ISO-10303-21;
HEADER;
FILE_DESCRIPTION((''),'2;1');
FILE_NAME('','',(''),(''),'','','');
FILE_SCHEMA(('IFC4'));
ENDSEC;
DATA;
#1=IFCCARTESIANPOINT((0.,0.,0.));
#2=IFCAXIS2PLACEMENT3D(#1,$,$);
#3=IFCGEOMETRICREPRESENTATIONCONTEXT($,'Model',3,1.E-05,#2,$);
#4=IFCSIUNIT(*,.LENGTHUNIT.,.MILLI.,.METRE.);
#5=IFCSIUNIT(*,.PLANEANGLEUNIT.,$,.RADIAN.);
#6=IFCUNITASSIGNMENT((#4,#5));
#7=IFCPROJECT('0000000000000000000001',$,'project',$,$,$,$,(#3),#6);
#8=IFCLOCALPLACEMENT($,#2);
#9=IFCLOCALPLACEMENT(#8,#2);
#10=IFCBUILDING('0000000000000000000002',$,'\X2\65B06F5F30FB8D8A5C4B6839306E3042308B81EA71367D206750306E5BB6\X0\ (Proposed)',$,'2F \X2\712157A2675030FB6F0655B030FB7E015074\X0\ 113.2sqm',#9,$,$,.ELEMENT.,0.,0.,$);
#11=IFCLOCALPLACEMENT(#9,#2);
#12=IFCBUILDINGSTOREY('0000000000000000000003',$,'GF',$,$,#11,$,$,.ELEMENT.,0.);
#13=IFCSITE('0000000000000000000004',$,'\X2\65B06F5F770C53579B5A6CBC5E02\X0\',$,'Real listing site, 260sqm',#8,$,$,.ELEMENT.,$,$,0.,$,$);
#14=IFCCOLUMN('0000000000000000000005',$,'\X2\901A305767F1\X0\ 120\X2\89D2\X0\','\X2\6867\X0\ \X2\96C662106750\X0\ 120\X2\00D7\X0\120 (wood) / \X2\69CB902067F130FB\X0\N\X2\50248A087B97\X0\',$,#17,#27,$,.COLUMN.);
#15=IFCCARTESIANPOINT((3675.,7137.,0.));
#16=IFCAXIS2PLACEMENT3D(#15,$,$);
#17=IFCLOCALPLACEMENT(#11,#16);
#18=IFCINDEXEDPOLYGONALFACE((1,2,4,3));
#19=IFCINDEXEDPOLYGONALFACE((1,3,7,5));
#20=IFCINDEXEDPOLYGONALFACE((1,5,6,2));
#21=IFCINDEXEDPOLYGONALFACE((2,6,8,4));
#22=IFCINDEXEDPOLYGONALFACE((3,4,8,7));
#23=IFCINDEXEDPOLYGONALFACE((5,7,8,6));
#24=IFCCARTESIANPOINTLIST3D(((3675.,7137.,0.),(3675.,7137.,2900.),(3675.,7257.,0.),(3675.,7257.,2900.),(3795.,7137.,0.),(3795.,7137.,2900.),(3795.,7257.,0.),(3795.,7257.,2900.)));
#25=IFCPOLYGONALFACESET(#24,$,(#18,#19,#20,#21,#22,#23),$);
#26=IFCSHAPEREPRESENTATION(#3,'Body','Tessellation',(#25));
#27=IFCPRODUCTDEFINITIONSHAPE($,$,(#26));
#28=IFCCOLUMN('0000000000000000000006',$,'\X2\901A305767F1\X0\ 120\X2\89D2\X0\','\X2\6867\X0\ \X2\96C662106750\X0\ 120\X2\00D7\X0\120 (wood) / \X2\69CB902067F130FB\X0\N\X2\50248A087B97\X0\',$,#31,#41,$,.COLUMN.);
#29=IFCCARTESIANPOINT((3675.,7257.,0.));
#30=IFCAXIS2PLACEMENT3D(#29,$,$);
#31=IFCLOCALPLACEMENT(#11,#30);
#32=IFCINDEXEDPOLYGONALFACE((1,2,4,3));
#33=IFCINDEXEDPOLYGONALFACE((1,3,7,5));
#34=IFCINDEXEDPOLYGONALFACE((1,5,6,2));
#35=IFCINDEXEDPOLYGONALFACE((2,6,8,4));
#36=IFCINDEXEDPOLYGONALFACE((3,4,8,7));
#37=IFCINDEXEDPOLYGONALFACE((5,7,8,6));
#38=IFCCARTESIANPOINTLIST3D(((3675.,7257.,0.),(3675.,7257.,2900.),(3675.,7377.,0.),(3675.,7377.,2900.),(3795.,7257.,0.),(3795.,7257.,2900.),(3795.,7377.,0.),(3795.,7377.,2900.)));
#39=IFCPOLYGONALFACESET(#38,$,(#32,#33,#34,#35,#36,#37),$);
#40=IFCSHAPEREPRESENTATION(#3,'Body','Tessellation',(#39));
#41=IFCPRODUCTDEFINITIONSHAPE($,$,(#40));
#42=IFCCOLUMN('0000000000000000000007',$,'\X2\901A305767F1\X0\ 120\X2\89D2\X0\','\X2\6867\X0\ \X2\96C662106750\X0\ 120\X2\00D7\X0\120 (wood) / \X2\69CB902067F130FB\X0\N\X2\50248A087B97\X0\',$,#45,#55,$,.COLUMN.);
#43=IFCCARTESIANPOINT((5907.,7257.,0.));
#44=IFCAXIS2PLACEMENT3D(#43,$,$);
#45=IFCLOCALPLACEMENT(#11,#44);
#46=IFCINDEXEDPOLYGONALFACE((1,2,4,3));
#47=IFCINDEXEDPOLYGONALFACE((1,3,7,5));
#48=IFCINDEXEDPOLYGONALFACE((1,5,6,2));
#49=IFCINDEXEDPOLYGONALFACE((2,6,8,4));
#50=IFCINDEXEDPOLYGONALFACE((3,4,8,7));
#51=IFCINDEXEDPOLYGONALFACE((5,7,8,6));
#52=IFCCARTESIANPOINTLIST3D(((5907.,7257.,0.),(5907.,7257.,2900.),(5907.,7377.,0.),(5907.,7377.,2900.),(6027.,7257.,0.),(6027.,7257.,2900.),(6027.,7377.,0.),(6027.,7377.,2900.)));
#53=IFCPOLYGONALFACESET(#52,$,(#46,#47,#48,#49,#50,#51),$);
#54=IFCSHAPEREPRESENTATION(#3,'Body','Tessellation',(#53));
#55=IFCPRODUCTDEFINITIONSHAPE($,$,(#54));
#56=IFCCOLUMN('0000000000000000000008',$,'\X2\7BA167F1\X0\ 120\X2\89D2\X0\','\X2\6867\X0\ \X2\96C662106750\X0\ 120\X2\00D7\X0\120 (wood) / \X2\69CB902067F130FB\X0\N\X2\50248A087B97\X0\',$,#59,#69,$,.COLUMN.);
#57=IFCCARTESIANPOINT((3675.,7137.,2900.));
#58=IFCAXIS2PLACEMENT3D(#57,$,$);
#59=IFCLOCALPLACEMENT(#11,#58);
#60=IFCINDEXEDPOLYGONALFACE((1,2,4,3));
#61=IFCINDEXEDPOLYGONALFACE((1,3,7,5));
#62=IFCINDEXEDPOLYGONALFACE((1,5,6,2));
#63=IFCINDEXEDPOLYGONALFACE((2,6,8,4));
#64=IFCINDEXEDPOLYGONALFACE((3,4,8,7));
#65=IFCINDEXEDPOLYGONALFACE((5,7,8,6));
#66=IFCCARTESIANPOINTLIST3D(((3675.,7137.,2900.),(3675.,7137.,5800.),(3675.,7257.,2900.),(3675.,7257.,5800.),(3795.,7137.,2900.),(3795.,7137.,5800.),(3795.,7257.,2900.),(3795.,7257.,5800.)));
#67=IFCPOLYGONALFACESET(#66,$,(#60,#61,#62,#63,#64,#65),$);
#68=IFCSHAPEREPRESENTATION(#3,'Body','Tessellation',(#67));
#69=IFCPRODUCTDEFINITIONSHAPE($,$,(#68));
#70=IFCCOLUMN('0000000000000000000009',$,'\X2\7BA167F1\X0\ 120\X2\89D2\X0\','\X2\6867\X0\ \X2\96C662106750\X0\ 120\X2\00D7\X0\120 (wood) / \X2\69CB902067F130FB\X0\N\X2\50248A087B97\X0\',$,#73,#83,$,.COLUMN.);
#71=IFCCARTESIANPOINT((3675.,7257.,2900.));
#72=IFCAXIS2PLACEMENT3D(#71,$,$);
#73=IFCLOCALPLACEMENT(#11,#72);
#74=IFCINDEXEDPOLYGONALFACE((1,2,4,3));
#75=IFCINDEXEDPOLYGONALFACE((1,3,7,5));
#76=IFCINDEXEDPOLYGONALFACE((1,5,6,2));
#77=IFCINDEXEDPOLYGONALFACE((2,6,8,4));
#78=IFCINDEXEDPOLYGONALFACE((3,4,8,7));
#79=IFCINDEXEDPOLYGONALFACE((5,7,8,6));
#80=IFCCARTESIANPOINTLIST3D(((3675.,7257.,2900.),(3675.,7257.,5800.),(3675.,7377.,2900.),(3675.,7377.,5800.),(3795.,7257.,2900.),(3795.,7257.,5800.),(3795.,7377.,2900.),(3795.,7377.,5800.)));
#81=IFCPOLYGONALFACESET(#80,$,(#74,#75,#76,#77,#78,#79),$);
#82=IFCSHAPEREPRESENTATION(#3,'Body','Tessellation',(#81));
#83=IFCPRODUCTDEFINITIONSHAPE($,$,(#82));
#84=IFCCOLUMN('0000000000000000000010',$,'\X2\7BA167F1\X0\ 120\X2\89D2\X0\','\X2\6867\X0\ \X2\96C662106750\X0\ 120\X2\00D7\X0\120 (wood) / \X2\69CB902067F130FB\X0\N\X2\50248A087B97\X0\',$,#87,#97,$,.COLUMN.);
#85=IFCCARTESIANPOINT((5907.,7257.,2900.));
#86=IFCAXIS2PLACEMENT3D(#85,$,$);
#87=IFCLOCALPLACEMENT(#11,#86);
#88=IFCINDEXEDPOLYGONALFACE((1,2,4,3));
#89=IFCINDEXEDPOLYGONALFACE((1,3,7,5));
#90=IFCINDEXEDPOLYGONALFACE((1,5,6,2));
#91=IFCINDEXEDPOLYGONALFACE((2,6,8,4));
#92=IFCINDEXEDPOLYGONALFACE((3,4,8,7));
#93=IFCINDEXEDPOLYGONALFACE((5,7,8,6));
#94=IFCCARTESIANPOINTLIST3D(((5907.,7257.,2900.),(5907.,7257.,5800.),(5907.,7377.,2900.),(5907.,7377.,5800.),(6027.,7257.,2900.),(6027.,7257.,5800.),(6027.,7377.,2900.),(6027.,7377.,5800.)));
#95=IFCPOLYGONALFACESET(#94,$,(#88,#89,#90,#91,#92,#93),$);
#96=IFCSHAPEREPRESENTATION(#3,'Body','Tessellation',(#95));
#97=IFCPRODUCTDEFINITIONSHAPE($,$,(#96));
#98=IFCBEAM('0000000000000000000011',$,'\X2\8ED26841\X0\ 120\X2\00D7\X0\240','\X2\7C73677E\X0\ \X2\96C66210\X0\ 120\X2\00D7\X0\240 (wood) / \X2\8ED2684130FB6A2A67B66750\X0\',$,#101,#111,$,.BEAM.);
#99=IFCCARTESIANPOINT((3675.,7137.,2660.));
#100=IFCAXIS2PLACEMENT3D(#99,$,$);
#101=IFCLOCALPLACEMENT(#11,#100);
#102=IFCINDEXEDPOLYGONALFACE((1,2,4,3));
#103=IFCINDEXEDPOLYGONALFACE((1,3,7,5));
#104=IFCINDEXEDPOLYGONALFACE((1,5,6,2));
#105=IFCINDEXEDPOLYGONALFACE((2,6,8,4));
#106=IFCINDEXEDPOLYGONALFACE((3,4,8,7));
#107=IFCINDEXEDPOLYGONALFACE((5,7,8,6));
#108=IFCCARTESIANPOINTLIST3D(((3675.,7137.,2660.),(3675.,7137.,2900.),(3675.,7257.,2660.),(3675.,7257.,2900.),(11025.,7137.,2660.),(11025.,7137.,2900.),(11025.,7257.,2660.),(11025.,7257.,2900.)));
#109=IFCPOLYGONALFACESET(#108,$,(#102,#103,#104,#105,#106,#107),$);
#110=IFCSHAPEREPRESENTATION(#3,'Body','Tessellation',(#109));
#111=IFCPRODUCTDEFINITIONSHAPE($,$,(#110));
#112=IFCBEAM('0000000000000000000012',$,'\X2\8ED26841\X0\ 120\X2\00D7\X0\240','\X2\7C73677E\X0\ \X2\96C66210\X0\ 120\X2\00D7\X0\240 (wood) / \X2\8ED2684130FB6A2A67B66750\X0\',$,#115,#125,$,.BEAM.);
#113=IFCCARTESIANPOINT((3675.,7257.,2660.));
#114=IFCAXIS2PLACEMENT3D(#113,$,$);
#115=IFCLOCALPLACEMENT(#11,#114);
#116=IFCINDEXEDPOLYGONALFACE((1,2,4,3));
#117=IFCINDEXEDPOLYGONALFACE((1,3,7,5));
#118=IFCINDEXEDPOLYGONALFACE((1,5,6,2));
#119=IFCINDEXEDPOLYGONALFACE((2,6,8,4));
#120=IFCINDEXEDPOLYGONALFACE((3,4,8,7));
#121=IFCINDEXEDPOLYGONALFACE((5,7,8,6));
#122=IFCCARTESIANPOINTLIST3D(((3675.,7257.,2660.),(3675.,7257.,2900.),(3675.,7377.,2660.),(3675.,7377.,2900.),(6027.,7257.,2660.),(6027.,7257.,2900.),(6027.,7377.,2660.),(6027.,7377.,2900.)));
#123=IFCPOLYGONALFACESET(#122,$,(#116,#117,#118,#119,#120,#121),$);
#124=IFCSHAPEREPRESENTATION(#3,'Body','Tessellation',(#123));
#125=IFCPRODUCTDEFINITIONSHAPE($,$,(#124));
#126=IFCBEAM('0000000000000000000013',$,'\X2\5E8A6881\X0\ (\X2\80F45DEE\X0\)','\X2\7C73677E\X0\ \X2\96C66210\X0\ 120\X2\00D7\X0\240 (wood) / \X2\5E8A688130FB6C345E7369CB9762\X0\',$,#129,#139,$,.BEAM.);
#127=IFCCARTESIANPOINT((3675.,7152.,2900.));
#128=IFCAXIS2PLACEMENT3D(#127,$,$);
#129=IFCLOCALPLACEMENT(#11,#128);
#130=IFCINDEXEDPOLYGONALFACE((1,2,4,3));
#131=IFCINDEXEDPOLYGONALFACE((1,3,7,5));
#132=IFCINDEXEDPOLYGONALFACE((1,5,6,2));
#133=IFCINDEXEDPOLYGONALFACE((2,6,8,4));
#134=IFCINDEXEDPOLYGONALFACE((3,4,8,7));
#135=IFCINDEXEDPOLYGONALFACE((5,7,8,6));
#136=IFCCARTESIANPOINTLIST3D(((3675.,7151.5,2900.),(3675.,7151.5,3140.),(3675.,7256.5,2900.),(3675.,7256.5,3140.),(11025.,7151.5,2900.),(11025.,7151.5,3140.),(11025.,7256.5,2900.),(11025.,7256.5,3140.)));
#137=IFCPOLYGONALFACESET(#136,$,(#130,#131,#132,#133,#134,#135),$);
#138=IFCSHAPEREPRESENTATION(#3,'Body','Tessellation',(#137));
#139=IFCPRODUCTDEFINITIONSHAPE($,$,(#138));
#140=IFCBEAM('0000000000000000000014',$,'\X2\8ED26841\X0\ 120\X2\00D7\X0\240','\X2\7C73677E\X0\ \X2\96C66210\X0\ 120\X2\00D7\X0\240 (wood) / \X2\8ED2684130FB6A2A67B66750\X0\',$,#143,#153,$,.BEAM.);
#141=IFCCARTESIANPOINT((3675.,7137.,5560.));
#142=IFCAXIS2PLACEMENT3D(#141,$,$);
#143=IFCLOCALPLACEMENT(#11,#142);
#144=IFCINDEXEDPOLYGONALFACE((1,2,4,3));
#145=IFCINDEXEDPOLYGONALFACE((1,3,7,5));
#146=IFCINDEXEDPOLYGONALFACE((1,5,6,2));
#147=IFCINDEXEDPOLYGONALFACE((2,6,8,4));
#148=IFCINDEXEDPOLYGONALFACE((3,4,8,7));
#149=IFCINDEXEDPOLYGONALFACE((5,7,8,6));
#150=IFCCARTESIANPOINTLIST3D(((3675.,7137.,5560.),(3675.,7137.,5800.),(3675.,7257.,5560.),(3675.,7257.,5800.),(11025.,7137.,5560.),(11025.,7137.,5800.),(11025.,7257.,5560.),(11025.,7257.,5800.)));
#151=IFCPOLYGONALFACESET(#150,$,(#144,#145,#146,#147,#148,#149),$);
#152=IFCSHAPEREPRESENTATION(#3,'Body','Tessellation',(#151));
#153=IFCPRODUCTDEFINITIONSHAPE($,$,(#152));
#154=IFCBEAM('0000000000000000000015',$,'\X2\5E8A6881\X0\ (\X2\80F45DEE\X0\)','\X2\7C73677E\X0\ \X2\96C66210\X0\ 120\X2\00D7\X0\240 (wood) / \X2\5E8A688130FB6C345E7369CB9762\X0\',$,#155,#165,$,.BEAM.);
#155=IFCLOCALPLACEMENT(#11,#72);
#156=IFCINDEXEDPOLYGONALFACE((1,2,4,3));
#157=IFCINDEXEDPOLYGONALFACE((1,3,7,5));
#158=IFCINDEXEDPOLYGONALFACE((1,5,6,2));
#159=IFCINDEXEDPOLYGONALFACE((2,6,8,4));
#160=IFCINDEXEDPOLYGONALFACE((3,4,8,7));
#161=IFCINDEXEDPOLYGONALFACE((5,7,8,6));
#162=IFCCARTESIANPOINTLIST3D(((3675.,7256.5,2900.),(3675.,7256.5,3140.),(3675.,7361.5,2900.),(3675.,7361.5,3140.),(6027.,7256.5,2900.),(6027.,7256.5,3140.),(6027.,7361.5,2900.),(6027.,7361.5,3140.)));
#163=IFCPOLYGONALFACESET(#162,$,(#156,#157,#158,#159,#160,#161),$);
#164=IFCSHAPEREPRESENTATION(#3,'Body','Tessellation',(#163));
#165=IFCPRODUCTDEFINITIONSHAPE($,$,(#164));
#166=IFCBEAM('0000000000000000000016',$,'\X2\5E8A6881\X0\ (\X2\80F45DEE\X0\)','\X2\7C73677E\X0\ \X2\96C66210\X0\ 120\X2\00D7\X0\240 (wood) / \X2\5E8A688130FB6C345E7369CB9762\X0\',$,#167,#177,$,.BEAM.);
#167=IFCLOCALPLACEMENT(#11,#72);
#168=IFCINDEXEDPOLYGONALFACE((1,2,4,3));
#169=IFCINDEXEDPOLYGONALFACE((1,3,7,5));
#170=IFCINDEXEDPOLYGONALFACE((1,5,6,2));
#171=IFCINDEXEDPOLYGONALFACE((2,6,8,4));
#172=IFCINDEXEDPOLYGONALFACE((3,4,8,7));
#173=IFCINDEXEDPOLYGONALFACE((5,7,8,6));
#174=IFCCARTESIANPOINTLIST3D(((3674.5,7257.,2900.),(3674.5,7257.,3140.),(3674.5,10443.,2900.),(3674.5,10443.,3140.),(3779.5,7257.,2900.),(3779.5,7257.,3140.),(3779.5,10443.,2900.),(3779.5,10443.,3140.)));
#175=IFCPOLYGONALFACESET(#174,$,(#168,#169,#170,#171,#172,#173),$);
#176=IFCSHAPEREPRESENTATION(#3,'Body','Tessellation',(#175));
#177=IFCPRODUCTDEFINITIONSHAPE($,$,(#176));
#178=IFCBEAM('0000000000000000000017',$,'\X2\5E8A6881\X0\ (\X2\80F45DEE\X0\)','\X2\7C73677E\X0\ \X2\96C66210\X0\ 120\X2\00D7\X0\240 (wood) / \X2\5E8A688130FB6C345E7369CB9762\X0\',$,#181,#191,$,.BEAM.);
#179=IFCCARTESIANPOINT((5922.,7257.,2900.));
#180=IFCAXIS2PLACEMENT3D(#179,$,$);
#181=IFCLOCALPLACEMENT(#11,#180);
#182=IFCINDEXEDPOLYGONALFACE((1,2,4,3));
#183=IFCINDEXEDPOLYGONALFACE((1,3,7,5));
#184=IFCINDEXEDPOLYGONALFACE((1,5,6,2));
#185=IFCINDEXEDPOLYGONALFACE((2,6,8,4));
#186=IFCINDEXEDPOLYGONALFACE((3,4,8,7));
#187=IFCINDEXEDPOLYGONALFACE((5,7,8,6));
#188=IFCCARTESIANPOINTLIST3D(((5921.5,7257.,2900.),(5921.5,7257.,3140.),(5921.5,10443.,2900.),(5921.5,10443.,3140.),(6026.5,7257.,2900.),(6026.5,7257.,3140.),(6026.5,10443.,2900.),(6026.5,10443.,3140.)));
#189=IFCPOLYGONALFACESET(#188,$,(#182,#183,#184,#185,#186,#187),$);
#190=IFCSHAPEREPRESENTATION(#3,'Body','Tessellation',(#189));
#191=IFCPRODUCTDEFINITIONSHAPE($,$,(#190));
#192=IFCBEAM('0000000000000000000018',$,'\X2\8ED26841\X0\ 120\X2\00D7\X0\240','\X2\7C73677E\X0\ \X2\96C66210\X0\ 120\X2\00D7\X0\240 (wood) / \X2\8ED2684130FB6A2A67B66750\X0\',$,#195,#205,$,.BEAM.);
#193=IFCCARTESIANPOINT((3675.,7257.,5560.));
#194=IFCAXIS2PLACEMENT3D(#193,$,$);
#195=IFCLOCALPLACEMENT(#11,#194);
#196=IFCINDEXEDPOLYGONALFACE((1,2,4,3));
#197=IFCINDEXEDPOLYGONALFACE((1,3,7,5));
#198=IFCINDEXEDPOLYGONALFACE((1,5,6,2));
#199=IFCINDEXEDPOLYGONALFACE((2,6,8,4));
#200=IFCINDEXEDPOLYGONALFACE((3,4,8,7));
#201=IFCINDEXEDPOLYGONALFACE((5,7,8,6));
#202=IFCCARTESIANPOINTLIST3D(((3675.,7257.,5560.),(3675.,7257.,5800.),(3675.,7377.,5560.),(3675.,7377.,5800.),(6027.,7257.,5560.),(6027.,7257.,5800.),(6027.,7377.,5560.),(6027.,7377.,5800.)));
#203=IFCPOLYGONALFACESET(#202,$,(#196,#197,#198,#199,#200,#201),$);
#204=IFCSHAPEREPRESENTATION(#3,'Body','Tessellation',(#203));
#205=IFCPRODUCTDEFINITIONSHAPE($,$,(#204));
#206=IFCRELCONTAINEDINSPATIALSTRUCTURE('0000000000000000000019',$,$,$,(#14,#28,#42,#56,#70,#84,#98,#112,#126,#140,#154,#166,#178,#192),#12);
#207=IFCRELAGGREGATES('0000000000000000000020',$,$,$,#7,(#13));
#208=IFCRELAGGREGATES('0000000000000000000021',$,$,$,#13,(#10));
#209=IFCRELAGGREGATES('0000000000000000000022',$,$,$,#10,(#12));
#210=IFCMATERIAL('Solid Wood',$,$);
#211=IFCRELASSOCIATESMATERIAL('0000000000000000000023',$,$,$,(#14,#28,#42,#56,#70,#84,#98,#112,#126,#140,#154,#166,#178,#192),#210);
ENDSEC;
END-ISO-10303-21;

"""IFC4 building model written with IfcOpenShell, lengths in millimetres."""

from ifc_helpers import new_model, si_unit, frame, frame_2d, origin, place, context, project, spatial, rectangle, extrude, material, element, save


model = new_model("IFC4")

# Units and contexts
model_context = context("Model", 3, precision=1e-05, world=origin())
ifc_project = project(units=[si_unit("LENGTHUNIT", "METRE", prefix="MILLI"), si_unit("PLANEANGLEUNIT", "RADIAN")], contexts=[model_context])

# Site, building, storey
site_placement = place(None, origin())
site = spatial("IfcSite", under=ifc_project, at=site_placement, Name="新潟県南魚沼市", ObjectType="Real listing site, 260sqm", CompositionType="ELEMENT", RefElevation=0.0)
building_placement = place(site_placement, origin())
building = spatial("IfcBuilding", under=site, at=building_placement, Name="新潟・越屋根のある自然素材の家 (Proposed)", ObjectType="2F 無垢材・漆喰・縁側 113.2sqm", CompositionType="ELEMENT", ElevationOfRefHeight=0.0, ElevationOfTerrain=0.0)
storey_placement = place(building_placement, origin())
storey = spatial("IfcBuildingStorey", under=building, at=storey_placement, Name="GF", CompositionType="ELEMENT", Elevation=0.0)

# Columns
ifc_material_1 = material(Name="Solid Wood")
column_1_placement = place(storey_placement, frame((3675.0, 7137.0, 0.0)))
element("IfcColumn", 1, at=column_1_placement, inside=storey, material=ifc_material_1, Name="通し柱 120角", Description="桧 集成材 120×120 (wood) / 構造柱・N値計算", PredefinedType="COLUMN", context=model_context, shape_type="SweptSolid", body=[
    extrude(rectangle(XDim=120.0, YDim=120.0, at=frame_2d((60.0, 60.0))), frame((3675.0, 7137.0, 0.0)), (0.0, 0.0, 1.0), 2900.0),
])
column_2_placement = place(storey_placement, frame((3675.0, 7257.0, 0.0)))
element("IfcColumn", 2, at=column_2_placement, inside=storey, material=ifc_material_1, Name="通し柱 120角", Description="桧 集成材 120×120 (wood) / 構造柱・N値計算", PredefinedType="COLUMN", context=model_context, shape_type="SweptSolid", body=[
    extrude(rectangle(XDim=120.0, YDim=120.0, at=frame_2d((60.0, 60.0))), frame((3675.0, 7257.0, 0.0)), (0.0, 0.0, 1.0), 2900.0),
])
column_3_placement = place(storey_placement, frame((5907.0, 7257.0, 0.0)))
element("IfcColumn", 3, at=column_3_placement, inside=storey, material=ifc_material_1, Name="通し柱 120角", Description="桧 集成材 120×120 (wood) / 構造柱・N値計算", PredefinedType="COLUMN", context=model_context, shape_type="SweptSolid", body=[
    extrude(rectangle(XDim=120.0, YDim=120.0, at=frame_2d((60.0, 60.0))), frame((5907.0, 7257.0, 0.0)), (0.0, 0.0, 1.0), 2900.0),
])
column_4_placement = place(storey_placement, frame((3675.0, 7137.0, 2900.0)))
element("IfcColumn", 4, at=column_4_placement, inside=storey, material=ifc_material_1, Name="管柱 120角", Description="桧 集成材 120×120 (wood) / 構造柱・N値計算", PredefinedType="COLUMN", context=model_context, shape_type="SweptSolid", body=[
    extrude(rectangle(XDim=120.0, YDim=120.0, at=frame_2d((60.0, 60.0))), frame((3675.0, 7137.0, 2900.0)), (0.0, 0.0, 1.0), 2900.0),
])
column_5_placement = place(storey_placement, frame((3675.0, 7257.0, 2900.0)))
element("IfcColumn", 5, at=column_5_placement, inside=storey, material=ifc_material_1, Name="管柱 120角", Description="桧 集成材 120×120 (wood) / 構造柱・N値計算", PredefinedType="COLUMN", context=model_context, shape_type="SweptSolid", body=[
    extrude(rectangle(XDim=120.0, YDim=120.0, at=frame_2d((60.0, 60.0))), frame((3675.0, 7257.0, 2900.0)), (0.0, 0.0, 1.0), 2900.0),
])
column_6_placement = place(storey_placement, frame((5907.0, 7257.0, 2900.0)))
element("IfcColumn", 6, at=column_6_placement, inside=storey, material=ifc_material_1, Name="管柱 120角", Description="桧 集成材 120×120 (wood) / 構造柱・N値計算", PredefinedType="COLUMN", context=model_context, shape_type="SweptSolid", body=[
    extrude(rectangle(XDim=120.0, YDim=120.0, at=frame_2d((60.0, 60.0))), frame((5907.0, 7257.0, 2900.0)), (0.0, 0.0, 1.0), 2900.0),
])

# Beams
beam_1_placement = place(storey_placement, frame((3675.0, 7137.0, 2660.0)))
element("IfcBeam", 7, at=beam_1_placement, inside=storey, material=ifc_material_1, Name="軒桁 120×240", Description="米松 集成 120×240 (wood) / 軒桁・横架材", PredefinedType="BEAM", context=model_context, shape_type="SweptSolid", body=[
    extrude(rectangle(XDim=7350.0, YDim=120.0, at=frame_2d((3675.0, 60.0))), frame((3675.0, 7137.0, 2660.0)), (0.0, 0.0, 1.0), 240.0),
])
beam_2_placement = place(storey_placement, frame((3675.0, 7257.0, 2660.0)))
element("IfcBeam", 8, at=beam_2_placement, inside=storey, material=ifc_material_1, Name="軒桁 120×240", Description="米松 集成 120×240 (wood) / 軒桁・横架材", PredefinedType="BEAM", context=model_context, shape_type="SweptSolid", body=[
    extrude(rectangle(XDim=2352.0, YDim=120.0, at=frame_2d((1176.0, 60.0))), frame((3675.0, 7257.0, 2660.0)), (0.0, 0.0, 1.0), 240.0),
])
beam_3_placement = place(storey_placement, frame((3675.0, 7152.0, 2900.0)))
element("IfcBeam", 9, at=beam_3_placement, inside=storey, material=ifc_material_1, Name="床梁 (胴差)", Description="米松 集成 120×240 (wood) / 床梁・水平構面", PredefinedType="BEAM", context=model_context, shape_type="SweptSolid", body=[
    extrude(rectangle(XDim=7350.0, YDim=105.0, at=frame_2d((3675.0, 52.0))), frame((3675.0, 7152.0, 2900.0)), (0.0, 0.0, 1.0), 240.0),
])
beam_4_placement = place(storey_placement, frame((3675.0, 7137.0, 5560.0)))
element("IfcBeam", 10, at=beam_4_placement, inside=storey, material=ifc_material_1, Name="軒桁 120×240", Description="米松 集成 120×240 (wood) / 軒桁・横架材", PredefinedType="BEAM", context=model_context, shape_type="SweptSolid", body=[
    extrude(rectangle(XDim=7350.0, YDim=120.0, at=frame_2d((3675.0, 60.0))), frame((3675.0, 7137.0, 5560.0)), (0.0, 0.0, 1.0), 240.0),
])
beam_5_placement = place(storey_placement, frame((3675.0, 7257.0, 2900.0)))
element("IfcBeam", 11, at=beam_5_placement, inside=storey, material=ifc_material_1, Name="床梁 (胴差)", Description="米松 集成 120×240 (wood) / 床梁・水平構面", PredefinedType="BEAM", context=model_context, shape_type="SweptSolid", body=[
    extrude(rectangle(XDim=2352.0, YDim=105.0, at=frame_2d((1176.0, 52.0))), frame((3675.0, 7257.0, 2900.0)), (0.0, 0.0, 1.0), 240.0),
])
beam_6_placement = place(storey_placement, frame((3675.0, 7257.0, 2900.0)))
element("IfcBeam", 12, at=beam_6_placement, inside=storey, material=ifc_material_1, Name="床梁 (胴差)", Description="米松 集成 120×240 (wood) / 床梁・水平構面", PredefinedType="BEAM", context=model_context, shape_type="SweptSolid", body=[
    extrude(rectangle(XDim=105.0, YDim=3186.0, at=frame_2d((52.0, 1593.0))), frame((3675.0, 7257.0, 2900.0)), (0.0, 0.0, 1.0), 240.0),
])
beam_7_placement = place(storey_placement, frame((5922.0, 7257.0, 2900.0)))
element("IfcBeam", 13, at=beam_7_placement, inside=storey, material=ifc_material_1, Name="床梁 (胴差)", Description="米松 集成 120×240 (wood) / 床梁・水平構面", PredefinedType="BEAM", context=model_context, shape_type="SweptSolid", body=[
    extrude(rectangle(XDim=105.0, YDim=3186.0, at=frame_2d((52.0, 1593.0))), frame((5922.0, 7257.0, 2900.0)), (0.0, 0.0, 1.0), 240.0),
])
beam_8_placement = place(storey_placement, frame((3675.0, 7257.0, 5560.0)))
element("IfcBeam", 14, at=beam_8_placement, inside=storey, material=ifc_material_1, Name="軒桁 120×240", Description="米松 集成 120×240 (wood) / 軒桁・横架材", PredefinedType="BEAM", context=model_context, shape_type="SweptSolid", body=[
    extrude(rectangle(XDim=2352.0, YDim=120.0, at=frame_2d((1176.0, 60.0))), frame((3675.0, 7257.0, 5560.0)), (0.0, 0.0, 1.0), 240.0),
])

save(model, "model.ifc")
